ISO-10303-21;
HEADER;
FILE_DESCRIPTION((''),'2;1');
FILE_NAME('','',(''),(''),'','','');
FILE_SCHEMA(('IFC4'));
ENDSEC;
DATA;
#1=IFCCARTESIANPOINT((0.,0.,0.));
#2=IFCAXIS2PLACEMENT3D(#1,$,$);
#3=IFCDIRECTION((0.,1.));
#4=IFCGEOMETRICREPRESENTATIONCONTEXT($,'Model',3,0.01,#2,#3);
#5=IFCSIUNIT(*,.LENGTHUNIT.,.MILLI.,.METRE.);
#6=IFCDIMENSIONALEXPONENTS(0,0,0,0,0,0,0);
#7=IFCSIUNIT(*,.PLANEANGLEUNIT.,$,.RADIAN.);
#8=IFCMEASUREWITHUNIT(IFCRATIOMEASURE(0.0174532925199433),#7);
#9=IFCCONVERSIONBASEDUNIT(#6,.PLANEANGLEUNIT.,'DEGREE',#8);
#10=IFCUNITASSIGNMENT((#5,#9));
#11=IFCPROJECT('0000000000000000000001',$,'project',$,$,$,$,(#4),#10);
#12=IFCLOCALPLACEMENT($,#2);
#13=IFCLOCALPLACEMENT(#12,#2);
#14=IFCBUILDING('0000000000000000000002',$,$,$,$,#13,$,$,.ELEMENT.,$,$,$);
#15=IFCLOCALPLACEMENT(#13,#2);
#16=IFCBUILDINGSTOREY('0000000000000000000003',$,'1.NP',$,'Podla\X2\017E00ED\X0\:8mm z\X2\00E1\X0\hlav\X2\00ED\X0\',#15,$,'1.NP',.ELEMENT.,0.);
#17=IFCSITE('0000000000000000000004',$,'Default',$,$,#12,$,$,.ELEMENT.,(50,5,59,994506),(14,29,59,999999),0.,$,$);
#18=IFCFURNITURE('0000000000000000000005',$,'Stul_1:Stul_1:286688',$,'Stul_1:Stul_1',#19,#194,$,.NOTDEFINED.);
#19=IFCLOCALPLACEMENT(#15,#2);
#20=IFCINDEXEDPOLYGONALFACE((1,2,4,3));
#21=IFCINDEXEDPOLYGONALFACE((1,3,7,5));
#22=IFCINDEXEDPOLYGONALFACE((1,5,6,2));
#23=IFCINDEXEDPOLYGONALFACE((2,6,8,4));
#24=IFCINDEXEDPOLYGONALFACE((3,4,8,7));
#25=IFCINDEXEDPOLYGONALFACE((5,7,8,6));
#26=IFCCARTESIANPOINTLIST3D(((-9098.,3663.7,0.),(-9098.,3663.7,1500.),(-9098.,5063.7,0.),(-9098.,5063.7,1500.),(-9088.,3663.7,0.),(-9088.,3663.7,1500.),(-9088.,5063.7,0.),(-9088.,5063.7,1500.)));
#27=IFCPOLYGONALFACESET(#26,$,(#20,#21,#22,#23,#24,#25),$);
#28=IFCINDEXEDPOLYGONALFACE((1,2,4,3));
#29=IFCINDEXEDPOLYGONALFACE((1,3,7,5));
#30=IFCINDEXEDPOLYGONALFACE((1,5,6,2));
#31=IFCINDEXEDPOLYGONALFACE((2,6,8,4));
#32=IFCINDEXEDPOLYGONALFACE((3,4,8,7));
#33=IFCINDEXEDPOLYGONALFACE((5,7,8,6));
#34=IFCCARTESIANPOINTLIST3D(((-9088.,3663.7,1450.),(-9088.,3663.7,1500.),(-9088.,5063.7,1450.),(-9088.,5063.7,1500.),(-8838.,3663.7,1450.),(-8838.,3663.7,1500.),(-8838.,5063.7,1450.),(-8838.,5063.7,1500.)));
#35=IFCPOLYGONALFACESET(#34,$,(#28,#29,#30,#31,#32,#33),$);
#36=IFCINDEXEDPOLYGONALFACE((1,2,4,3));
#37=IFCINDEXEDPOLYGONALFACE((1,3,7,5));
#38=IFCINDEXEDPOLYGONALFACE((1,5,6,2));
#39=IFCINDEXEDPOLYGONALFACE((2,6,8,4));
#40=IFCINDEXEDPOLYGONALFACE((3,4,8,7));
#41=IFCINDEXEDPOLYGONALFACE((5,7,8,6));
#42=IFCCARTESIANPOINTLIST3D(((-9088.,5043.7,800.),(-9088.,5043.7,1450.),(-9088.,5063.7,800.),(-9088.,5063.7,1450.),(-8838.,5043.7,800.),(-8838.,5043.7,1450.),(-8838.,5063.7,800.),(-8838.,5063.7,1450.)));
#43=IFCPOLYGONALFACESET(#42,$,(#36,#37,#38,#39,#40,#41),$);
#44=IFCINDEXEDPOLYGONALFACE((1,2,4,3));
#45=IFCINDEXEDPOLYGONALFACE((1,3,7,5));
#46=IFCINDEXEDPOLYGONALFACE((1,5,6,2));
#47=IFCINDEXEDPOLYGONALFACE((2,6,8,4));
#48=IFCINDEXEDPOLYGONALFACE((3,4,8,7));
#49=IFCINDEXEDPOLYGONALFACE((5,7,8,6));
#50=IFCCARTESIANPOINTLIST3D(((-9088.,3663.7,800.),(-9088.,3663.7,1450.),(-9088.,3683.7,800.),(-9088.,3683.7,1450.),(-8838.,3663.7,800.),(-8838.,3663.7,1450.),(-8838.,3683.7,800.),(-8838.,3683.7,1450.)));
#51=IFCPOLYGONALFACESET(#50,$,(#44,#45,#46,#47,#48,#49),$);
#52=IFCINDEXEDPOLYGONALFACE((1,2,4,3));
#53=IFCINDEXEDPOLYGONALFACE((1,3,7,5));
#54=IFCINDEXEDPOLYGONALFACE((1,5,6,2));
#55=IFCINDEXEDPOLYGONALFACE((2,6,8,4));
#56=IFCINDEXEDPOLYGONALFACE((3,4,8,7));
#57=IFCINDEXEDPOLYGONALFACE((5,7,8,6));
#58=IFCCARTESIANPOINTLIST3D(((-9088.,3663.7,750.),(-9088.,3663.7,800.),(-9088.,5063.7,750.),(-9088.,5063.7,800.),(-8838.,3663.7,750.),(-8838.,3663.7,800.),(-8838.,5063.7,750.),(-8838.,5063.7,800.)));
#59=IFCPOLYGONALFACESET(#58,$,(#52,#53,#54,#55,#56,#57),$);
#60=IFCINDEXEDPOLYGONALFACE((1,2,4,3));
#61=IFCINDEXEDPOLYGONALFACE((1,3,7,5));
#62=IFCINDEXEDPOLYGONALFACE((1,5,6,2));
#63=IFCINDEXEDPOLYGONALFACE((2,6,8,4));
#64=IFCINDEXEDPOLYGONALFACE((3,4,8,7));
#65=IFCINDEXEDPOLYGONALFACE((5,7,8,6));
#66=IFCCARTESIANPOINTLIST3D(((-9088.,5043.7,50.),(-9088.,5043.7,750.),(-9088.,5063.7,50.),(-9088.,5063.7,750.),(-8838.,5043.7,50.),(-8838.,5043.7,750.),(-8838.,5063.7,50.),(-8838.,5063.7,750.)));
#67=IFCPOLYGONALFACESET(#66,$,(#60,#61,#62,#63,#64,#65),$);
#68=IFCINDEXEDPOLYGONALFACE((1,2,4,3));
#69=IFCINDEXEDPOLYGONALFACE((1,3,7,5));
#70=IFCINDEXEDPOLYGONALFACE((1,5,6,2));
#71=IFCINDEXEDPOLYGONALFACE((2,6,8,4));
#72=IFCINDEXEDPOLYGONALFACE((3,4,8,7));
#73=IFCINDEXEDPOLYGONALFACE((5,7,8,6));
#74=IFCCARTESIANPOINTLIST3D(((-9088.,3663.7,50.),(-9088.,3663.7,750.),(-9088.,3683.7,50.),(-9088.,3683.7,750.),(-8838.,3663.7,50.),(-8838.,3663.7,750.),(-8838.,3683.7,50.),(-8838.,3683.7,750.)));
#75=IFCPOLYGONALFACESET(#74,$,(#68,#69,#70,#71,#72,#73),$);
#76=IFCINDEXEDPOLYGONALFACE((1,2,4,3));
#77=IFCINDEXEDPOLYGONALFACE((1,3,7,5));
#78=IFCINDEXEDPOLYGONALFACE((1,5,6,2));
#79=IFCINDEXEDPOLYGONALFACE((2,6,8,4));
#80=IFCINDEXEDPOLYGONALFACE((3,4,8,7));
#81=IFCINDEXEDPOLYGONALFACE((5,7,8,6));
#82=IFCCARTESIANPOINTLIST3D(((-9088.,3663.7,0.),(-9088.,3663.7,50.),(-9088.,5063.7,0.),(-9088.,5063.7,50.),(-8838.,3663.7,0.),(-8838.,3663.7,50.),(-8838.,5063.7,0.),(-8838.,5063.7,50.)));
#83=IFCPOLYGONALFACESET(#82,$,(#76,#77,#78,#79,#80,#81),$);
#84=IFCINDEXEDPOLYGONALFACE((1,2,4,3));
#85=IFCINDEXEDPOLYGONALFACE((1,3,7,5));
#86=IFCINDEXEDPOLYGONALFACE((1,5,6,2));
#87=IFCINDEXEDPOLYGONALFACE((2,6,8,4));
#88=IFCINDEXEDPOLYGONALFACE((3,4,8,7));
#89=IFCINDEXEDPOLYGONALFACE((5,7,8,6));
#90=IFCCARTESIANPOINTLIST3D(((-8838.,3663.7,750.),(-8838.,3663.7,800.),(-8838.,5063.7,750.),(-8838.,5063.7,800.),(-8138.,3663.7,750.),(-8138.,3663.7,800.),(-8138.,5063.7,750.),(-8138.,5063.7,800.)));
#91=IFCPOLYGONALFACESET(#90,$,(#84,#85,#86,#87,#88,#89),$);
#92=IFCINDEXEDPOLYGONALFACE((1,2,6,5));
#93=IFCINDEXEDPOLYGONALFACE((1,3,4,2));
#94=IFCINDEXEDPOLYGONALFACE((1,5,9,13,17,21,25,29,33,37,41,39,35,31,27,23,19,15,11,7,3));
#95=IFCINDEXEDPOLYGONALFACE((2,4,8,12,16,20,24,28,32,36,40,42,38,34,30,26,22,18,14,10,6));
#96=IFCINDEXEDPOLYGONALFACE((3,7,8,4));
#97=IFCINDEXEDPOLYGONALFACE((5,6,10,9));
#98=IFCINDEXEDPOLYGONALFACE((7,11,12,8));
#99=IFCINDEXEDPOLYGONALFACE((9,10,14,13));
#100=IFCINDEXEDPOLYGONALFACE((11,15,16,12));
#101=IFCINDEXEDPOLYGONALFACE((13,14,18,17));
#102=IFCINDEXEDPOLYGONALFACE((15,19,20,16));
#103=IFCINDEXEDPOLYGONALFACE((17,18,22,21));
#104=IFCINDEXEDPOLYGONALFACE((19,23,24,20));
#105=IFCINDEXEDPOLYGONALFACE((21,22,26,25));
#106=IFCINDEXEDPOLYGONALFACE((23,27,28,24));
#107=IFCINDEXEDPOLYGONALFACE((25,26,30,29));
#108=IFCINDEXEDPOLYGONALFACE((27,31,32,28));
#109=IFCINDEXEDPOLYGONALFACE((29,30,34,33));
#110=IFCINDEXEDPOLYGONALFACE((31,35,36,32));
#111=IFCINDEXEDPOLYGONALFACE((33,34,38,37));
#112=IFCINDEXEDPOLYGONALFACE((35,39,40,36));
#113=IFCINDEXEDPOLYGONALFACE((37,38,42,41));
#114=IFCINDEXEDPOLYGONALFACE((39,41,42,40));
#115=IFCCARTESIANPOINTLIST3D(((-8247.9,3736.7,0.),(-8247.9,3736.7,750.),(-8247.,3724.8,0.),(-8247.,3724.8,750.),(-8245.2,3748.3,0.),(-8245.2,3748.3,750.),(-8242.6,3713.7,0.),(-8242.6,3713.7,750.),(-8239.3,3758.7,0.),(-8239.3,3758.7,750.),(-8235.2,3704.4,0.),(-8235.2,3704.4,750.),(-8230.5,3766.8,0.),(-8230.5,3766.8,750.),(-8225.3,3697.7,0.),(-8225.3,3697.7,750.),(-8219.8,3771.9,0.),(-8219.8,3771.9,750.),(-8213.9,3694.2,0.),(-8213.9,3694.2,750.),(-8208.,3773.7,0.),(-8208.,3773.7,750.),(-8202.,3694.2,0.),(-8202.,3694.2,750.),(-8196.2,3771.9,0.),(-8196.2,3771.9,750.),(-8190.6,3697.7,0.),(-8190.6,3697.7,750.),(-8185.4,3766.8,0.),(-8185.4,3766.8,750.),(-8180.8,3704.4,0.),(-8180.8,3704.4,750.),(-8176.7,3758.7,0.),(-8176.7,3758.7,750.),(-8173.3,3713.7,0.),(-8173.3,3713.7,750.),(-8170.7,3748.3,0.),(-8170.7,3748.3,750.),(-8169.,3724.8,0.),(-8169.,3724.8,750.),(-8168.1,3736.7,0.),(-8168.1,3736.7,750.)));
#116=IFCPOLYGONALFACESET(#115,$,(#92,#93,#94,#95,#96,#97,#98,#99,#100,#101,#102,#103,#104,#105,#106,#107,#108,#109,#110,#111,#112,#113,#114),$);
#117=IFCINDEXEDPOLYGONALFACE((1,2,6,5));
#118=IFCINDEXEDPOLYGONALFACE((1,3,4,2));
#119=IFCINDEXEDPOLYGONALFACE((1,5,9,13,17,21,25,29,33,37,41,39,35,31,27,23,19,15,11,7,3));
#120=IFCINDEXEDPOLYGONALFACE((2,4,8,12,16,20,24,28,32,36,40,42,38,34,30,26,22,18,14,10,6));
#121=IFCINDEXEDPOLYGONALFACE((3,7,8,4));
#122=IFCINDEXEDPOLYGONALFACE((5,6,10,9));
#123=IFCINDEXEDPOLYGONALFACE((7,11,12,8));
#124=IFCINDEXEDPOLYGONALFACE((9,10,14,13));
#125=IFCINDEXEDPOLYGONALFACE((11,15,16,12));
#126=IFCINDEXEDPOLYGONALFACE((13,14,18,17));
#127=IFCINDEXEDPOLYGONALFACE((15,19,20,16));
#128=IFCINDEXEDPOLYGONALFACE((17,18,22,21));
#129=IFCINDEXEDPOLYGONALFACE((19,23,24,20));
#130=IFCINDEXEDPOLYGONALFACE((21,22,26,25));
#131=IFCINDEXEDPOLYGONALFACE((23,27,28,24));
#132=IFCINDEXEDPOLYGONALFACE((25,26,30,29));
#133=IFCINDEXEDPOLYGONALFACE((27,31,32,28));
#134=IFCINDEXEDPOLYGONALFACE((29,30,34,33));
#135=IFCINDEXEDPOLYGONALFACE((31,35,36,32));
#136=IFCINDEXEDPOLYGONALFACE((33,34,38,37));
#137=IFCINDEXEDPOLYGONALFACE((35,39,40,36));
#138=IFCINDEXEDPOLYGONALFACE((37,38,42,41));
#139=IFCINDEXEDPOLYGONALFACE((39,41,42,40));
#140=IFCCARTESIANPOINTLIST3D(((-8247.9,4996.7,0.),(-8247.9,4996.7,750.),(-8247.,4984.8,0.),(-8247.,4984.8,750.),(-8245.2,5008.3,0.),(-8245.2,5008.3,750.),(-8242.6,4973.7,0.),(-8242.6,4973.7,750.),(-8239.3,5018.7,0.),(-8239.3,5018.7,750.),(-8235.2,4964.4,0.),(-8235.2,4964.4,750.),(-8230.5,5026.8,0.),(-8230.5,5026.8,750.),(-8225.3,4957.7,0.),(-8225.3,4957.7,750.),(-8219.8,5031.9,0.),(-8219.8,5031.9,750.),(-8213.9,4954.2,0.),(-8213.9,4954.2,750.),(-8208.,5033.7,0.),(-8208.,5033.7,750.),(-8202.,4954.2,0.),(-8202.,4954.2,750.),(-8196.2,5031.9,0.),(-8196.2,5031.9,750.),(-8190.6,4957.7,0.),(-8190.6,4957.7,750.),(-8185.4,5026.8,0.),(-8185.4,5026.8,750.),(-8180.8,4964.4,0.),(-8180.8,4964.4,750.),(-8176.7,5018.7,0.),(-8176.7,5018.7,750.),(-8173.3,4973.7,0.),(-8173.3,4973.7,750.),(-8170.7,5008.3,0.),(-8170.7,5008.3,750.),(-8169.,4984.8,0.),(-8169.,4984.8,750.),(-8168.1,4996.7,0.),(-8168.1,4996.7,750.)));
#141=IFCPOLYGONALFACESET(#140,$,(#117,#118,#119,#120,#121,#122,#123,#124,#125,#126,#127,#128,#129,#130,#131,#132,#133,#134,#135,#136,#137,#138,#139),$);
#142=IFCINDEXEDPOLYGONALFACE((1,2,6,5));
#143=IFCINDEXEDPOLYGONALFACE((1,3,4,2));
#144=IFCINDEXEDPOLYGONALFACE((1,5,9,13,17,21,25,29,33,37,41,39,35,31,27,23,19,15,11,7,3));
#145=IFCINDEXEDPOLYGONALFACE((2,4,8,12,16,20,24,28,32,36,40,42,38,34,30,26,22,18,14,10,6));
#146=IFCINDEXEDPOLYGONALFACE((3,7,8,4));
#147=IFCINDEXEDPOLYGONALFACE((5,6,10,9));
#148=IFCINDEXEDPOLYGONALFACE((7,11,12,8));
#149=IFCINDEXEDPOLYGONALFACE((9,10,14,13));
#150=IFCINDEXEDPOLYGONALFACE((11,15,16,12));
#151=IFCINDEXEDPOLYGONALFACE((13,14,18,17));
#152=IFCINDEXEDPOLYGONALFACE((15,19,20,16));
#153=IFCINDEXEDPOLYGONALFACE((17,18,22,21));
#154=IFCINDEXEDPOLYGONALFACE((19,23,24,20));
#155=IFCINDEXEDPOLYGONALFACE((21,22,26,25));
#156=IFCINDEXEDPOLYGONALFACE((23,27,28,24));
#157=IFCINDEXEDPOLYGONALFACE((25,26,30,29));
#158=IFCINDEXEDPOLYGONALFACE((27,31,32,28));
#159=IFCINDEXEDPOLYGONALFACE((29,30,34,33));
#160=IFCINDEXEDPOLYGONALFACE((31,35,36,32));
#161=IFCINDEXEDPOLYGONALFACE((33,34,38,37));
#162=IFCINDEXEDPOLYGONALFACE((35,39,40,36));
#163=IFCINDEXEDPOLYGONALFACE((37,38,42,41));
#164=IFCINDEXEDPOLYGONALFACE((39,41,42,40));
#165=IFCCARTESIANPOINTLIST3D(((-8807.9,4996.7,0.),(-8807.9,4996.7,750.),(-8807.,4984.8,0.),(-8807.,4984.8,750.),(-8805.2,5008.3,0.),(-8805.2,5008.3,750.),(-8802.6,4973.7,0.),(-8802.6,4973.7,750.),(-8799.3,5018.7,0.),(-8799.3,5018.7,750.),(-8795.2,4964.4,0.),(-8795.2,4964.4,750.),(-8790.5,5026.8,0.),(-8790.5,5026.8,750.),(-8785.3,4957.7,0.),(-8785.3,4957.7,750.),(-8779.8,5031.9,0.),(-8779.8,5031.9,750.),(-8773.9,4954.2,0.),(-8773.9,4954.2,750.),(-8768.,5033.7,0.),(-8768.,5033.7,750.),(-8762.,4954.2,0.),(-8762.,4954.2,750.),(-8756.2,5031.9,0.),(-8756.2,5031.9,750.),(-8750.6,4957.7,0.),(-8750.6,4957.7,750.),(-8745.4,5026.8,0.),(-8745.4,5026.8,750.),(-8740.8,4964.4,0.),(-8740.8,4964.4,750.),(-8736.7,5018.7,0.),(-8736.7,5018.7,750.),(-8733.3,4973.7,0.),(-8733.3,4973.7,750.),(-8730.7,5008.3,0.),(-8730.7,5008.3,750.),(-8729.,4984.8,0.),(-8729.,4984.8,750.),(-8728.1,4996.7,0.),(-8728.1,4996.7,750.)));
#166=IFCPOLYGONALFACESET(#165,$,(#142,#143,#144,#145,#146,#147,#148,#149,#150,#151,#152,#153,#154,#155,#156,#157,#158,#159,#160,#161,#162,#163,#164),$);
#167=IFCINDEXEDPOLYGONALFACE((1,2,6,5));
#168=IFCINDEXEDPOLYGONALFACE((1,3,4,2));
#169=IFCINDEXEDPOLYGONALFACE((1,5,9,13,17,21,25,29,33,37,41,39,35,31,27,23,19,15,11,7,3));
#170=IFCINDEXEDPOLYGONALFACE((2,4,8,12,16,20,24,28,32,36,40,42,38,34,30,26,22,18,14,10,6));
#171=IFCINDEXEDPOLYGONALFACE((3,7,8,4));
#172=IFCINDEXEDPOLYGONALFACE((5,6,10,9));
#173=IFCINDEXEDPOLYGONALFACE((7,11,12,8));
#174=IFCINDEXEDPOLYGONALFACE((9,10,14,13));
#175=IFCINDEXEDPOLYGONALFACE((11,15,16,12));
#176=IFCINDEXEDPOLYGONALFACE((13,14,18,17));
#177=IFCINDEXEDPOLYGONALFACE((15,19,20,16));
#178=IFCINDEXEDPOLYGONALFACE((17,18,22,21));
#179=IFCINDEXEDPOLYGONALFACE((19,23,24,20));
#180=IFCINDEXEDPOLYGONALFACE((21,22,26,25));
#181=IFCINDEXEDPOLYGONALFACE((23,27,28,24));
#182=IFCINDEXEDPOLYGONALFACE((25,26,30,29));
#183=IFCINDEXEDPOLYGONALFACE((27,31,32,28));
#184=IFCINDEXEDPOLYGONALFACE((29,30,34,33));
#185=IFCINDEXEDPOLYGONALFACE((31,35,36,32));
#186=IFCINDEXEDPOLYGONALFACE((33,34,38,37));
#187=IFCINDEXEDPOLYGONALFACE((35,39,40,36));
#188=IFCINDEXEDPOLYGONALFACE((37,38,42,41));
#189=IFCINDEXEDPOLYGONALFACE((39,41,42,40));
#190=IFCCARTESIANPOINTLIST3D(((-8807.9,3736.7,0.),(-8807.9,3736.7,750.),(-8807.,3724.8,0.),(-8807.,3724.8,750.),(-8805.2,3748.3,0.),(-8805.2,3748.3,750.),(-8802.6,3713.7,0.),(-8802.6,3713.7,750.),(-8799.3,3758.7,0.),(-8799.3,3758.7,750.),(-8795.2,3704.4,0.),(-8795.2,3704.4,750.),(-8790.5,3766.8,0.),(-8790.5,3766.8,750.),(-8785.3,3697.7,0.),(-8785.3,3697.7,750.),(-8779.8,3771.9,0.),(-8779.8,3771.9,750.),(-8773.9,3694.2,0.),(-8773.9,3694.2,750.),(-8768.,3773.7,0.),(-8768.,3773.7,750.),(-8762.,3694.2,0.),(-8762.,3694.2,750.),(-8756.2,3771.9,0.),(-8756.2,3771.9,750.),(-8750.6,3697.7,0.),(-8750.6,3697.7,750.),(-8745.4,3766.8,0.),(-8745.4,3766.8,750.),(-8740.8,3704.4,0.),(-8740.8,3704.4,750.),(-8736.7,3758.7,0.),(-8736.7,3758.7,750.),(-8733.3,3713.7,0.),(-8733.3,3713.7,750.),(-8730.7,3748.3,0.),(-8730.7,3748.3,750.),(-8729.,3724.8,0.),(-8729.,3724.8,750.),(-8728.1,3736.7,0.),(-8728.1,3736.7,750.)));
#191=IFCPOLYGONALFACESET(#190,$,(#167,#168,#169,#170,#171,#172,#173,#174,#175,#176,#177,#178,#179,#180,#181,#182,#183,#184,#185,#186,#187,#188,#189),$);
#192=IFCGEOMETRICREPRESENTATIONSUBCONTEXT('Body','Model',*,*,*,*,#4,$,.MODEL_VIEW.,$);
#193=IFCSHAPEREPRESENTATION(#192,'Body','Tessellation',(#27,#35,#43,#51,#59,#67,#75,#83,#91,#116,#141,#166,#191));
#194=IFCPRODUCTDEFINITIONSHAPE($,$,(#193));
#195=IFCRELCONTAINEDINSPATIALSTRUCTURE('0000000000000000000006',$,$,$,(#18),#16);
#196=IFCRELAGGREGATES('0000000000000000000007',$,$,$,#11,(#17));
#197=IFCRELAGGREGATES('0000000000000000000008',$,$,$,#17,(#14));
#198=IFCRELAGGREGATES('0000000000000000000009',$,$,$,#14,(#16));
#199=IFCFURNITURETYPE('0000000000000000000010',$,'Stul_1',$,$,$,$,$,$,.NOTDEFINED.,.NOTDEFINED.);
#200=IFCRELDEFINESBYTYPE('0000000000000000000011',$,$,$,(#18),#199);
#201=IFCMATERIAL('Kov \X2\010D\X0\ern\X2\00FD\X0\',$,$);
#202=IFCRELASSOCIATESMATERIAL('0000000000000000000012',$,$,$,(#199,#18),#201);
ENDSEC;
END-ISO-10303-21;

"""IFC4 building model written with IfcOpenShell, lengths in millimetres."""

from ifc_helpers import new_model, entity, si_unit, converted_unit, direction, frame, frame_2d, origin, origin_2d_with_axis, place, context, subcontext, project, spatial, rectangle, circle, extrude, source, transform, mapped, material, type_object, type_shapes, element, save


model = new_model("IFC4")

# Units and contexts
model_context = context("Model", 3, precision=0.01, world=origin(), true_north=direction((0.0, 1.0)))
body_context = subcontext(model_context, "Body", "Model", "MODEL_VIEW")
ifc_project = project(units=[si_unit("LENGTHUNIT", "METRE", prefix="MILLI"), converted_unit("PLANEANGLEUNIT", "DEGREE", entity("IfcRatioMeasure", 0.0174532925199433), si_unit("PLANEANGLEUNIT", "RADIAN"), dimensions=[0, 0, 0, 0, 0, 0, 0])], contexts=[model_context])

# Site, building, storey
site_placement = place(None, origin())
site = spatial("IfcSite", under=ifc_project, at=site_placement, Name="Default", CompositionType="ELEMENT", RefLatitude=(50, 5, 59, 994506), RefLongitude=(14, 29, 59, 999999), RefElevation=0.0)
building_placement = place(site_placement, origin())
building = spatial("IfcBuilding", under=site, at=building_placement, CompositionType="ELEMENT")
storey_placement = place(building_placement, origin())
storey = spatial("IfcBuildingStorey", under=building, at=storey_placement, Name="1.NP", ObjectType="Podlaží:8mm záhlaví", LongName="1.NP", CompositionType="ELEMENT", Elevation=0.0)

# Furniture
ifc_material_1 = material(Name="Kov černý")
furniture_type = type_object("IfcFurnitureType", Name="Stul_1", AssemblyPlace="NOTDEFINED", PredefinedType="NOTDEFINED", material=ifc_material_1)
shared_shape_1 = source(origin(), body_context, "Body", "SweptSolid", [
    extrude(rectangle(XDim=1400.0, YDim=10.0, at=origin_2d_with_axis()), frame((0.0, 605.0, 0.0), z_axis=(0.0, 0.0, 1.0), x_axis=(-1.0, 0.0, 0.0)), (0.0, 0.0, 1.0), 1500.0),
    extrude(rectangle(XDim=1400.0, YDim=250.0, at=frame_2d((0.0, 0.0), x_axis=(1.0, 0.0))), frame((0.0, 475.0, 1450.0), z_axis=(0.0, 0.0, 1.0), x_axis=(-1.0, 0.0, 0.0)), (0.0, 0.0, 1.0), 50.0),
    extrude(rectangle(XDim=20.0, YDim=250.0, at=origin_2d_with_axis()), frame((690.0, 475.0, 800.0), z_axis=(0.0, 0.0, 1.0), x_axis=(-1.0, 0.0, 0.0)), (0.0, 0.0, 1.0), 650.0),
    extrude(rectangle(XDim=20.0, YDim=250.0, at=frame_2d((0.0, 0.0), x_axis=(1.0, 0.0))), frame((-690.0, 475.0, 800.0), z_axis=(0.0, 0.0, 1.0), x_axis=(-1.0, 0.0, 0.0)), (0.0, 0.0, 1.0), 650.0),
    extrude(rectangle(XDim=1400.0, YDim=250.0, at=origin_2d_with_axis()), frame((0.0, 475.0, 750.0), z_axis=(0.0, 0.0, 1.0), x_axis=(-1.0, 0.0, 0.0)), (0.0, 0.0, 1.0), 50.0),
    extrude(rectangle(XDim=20.0, YDim=250.0, at=origin_2d_with_axis()), frame((690.0, 475.0, 50.0), z_axis=(0.0, 0.0, 1.0), x_axis=(-1.0, 0.0, 0.0)), (0.0, 0.0, 1.0), 700.0),
    extrude(rectangle(XDim=20.0, YDim=250.0, at=frame_2d((0.0, 0.0), x_axis=(1.0, 0.0))), frame((-690.0, 475.0, 50.0), z_axis=(0.0, 0.0, 1.0), x_axis=(-1.0, 0.0, 0.0)), (0.0, 0.0, 1.0), 700.0),
    extrude(rectangle(XDim=1400.0, YDim=250.0, at=origin_2d_with_axis()), frame((0.0, 475.0, 0.0), z_axis=(0.0, 0.0, 1.0), x_axis=(-1.0, 0.0, 0.0)), (0.0, 0.0, 1.0), 50.0),
    extrude(rectangle(XDim=1400.0, YDim=700.0, at=origin_2d_with_axis()), frame((0.0, 0.0, 750.0), z_axis=(0.0, 0.0, 1.0), x_axis=(-1.0, 0.0, 0.0)), (0.0, 0.0, 1.0), 50.0),
    extrude(circle(Radius=40.0, at=frame_2d((0.0, 0.0), x_axis=(1.0, 0.0))), frame((-630.0, -280.0, 0.0)), (0.0, 0.0, 1.0), 750.0),
    extrude(circle(Radius=40.0, at=frame_2d((0.0, 0.0), x_axis=(1.0, 0.0))), frame((630.0, -280.0, 0.0)), (0.0, 0.0, 1.0), 750.0),
    extrude(circle(Radius=40.0, at=frame_2d((0.0, 0.0), x_axis=(1.0, 0.0))), frame((630.0, 280.0, 0.0)), (0.0, 0.0, 1.0), 750.0),
    extrude(circle(Radius=40.0, at=frame_2d((0.0, 0.0), x_axis=(1.0, 0.0))), frame((-630.0, 280.0, 0.0)), (0.0, 0.0, 1.0), 750.0),
])
type_shapes(furniture_type, [shared_shape_1])
for number, where, z_axis, x_axis, name in (
    (1, (-8488.0, 4363.7, 0.0), (0.0, 0.0, 1.0), (0.0, 1.0, 0.0), "Stul_1:Stul_1:286688"),
):
    element("IfcFurniture", number, at=place(storey_placement, frame(where, z_axis=z_axis, x_axis=x_axis)), inside=storey, type_object=furniture_type, material=ifc_material_1, Name=name, ObjectType="Stul_1:Stul_1", PredefinedType="NOTDEFINED", context=body_context, shape_type="MappedRepresentation", body=[
        mapped(shared_shape_1, transform((0.0, 0.0, 0.0), scale=1.0)),
    ])

save(model, "model.ifc")
